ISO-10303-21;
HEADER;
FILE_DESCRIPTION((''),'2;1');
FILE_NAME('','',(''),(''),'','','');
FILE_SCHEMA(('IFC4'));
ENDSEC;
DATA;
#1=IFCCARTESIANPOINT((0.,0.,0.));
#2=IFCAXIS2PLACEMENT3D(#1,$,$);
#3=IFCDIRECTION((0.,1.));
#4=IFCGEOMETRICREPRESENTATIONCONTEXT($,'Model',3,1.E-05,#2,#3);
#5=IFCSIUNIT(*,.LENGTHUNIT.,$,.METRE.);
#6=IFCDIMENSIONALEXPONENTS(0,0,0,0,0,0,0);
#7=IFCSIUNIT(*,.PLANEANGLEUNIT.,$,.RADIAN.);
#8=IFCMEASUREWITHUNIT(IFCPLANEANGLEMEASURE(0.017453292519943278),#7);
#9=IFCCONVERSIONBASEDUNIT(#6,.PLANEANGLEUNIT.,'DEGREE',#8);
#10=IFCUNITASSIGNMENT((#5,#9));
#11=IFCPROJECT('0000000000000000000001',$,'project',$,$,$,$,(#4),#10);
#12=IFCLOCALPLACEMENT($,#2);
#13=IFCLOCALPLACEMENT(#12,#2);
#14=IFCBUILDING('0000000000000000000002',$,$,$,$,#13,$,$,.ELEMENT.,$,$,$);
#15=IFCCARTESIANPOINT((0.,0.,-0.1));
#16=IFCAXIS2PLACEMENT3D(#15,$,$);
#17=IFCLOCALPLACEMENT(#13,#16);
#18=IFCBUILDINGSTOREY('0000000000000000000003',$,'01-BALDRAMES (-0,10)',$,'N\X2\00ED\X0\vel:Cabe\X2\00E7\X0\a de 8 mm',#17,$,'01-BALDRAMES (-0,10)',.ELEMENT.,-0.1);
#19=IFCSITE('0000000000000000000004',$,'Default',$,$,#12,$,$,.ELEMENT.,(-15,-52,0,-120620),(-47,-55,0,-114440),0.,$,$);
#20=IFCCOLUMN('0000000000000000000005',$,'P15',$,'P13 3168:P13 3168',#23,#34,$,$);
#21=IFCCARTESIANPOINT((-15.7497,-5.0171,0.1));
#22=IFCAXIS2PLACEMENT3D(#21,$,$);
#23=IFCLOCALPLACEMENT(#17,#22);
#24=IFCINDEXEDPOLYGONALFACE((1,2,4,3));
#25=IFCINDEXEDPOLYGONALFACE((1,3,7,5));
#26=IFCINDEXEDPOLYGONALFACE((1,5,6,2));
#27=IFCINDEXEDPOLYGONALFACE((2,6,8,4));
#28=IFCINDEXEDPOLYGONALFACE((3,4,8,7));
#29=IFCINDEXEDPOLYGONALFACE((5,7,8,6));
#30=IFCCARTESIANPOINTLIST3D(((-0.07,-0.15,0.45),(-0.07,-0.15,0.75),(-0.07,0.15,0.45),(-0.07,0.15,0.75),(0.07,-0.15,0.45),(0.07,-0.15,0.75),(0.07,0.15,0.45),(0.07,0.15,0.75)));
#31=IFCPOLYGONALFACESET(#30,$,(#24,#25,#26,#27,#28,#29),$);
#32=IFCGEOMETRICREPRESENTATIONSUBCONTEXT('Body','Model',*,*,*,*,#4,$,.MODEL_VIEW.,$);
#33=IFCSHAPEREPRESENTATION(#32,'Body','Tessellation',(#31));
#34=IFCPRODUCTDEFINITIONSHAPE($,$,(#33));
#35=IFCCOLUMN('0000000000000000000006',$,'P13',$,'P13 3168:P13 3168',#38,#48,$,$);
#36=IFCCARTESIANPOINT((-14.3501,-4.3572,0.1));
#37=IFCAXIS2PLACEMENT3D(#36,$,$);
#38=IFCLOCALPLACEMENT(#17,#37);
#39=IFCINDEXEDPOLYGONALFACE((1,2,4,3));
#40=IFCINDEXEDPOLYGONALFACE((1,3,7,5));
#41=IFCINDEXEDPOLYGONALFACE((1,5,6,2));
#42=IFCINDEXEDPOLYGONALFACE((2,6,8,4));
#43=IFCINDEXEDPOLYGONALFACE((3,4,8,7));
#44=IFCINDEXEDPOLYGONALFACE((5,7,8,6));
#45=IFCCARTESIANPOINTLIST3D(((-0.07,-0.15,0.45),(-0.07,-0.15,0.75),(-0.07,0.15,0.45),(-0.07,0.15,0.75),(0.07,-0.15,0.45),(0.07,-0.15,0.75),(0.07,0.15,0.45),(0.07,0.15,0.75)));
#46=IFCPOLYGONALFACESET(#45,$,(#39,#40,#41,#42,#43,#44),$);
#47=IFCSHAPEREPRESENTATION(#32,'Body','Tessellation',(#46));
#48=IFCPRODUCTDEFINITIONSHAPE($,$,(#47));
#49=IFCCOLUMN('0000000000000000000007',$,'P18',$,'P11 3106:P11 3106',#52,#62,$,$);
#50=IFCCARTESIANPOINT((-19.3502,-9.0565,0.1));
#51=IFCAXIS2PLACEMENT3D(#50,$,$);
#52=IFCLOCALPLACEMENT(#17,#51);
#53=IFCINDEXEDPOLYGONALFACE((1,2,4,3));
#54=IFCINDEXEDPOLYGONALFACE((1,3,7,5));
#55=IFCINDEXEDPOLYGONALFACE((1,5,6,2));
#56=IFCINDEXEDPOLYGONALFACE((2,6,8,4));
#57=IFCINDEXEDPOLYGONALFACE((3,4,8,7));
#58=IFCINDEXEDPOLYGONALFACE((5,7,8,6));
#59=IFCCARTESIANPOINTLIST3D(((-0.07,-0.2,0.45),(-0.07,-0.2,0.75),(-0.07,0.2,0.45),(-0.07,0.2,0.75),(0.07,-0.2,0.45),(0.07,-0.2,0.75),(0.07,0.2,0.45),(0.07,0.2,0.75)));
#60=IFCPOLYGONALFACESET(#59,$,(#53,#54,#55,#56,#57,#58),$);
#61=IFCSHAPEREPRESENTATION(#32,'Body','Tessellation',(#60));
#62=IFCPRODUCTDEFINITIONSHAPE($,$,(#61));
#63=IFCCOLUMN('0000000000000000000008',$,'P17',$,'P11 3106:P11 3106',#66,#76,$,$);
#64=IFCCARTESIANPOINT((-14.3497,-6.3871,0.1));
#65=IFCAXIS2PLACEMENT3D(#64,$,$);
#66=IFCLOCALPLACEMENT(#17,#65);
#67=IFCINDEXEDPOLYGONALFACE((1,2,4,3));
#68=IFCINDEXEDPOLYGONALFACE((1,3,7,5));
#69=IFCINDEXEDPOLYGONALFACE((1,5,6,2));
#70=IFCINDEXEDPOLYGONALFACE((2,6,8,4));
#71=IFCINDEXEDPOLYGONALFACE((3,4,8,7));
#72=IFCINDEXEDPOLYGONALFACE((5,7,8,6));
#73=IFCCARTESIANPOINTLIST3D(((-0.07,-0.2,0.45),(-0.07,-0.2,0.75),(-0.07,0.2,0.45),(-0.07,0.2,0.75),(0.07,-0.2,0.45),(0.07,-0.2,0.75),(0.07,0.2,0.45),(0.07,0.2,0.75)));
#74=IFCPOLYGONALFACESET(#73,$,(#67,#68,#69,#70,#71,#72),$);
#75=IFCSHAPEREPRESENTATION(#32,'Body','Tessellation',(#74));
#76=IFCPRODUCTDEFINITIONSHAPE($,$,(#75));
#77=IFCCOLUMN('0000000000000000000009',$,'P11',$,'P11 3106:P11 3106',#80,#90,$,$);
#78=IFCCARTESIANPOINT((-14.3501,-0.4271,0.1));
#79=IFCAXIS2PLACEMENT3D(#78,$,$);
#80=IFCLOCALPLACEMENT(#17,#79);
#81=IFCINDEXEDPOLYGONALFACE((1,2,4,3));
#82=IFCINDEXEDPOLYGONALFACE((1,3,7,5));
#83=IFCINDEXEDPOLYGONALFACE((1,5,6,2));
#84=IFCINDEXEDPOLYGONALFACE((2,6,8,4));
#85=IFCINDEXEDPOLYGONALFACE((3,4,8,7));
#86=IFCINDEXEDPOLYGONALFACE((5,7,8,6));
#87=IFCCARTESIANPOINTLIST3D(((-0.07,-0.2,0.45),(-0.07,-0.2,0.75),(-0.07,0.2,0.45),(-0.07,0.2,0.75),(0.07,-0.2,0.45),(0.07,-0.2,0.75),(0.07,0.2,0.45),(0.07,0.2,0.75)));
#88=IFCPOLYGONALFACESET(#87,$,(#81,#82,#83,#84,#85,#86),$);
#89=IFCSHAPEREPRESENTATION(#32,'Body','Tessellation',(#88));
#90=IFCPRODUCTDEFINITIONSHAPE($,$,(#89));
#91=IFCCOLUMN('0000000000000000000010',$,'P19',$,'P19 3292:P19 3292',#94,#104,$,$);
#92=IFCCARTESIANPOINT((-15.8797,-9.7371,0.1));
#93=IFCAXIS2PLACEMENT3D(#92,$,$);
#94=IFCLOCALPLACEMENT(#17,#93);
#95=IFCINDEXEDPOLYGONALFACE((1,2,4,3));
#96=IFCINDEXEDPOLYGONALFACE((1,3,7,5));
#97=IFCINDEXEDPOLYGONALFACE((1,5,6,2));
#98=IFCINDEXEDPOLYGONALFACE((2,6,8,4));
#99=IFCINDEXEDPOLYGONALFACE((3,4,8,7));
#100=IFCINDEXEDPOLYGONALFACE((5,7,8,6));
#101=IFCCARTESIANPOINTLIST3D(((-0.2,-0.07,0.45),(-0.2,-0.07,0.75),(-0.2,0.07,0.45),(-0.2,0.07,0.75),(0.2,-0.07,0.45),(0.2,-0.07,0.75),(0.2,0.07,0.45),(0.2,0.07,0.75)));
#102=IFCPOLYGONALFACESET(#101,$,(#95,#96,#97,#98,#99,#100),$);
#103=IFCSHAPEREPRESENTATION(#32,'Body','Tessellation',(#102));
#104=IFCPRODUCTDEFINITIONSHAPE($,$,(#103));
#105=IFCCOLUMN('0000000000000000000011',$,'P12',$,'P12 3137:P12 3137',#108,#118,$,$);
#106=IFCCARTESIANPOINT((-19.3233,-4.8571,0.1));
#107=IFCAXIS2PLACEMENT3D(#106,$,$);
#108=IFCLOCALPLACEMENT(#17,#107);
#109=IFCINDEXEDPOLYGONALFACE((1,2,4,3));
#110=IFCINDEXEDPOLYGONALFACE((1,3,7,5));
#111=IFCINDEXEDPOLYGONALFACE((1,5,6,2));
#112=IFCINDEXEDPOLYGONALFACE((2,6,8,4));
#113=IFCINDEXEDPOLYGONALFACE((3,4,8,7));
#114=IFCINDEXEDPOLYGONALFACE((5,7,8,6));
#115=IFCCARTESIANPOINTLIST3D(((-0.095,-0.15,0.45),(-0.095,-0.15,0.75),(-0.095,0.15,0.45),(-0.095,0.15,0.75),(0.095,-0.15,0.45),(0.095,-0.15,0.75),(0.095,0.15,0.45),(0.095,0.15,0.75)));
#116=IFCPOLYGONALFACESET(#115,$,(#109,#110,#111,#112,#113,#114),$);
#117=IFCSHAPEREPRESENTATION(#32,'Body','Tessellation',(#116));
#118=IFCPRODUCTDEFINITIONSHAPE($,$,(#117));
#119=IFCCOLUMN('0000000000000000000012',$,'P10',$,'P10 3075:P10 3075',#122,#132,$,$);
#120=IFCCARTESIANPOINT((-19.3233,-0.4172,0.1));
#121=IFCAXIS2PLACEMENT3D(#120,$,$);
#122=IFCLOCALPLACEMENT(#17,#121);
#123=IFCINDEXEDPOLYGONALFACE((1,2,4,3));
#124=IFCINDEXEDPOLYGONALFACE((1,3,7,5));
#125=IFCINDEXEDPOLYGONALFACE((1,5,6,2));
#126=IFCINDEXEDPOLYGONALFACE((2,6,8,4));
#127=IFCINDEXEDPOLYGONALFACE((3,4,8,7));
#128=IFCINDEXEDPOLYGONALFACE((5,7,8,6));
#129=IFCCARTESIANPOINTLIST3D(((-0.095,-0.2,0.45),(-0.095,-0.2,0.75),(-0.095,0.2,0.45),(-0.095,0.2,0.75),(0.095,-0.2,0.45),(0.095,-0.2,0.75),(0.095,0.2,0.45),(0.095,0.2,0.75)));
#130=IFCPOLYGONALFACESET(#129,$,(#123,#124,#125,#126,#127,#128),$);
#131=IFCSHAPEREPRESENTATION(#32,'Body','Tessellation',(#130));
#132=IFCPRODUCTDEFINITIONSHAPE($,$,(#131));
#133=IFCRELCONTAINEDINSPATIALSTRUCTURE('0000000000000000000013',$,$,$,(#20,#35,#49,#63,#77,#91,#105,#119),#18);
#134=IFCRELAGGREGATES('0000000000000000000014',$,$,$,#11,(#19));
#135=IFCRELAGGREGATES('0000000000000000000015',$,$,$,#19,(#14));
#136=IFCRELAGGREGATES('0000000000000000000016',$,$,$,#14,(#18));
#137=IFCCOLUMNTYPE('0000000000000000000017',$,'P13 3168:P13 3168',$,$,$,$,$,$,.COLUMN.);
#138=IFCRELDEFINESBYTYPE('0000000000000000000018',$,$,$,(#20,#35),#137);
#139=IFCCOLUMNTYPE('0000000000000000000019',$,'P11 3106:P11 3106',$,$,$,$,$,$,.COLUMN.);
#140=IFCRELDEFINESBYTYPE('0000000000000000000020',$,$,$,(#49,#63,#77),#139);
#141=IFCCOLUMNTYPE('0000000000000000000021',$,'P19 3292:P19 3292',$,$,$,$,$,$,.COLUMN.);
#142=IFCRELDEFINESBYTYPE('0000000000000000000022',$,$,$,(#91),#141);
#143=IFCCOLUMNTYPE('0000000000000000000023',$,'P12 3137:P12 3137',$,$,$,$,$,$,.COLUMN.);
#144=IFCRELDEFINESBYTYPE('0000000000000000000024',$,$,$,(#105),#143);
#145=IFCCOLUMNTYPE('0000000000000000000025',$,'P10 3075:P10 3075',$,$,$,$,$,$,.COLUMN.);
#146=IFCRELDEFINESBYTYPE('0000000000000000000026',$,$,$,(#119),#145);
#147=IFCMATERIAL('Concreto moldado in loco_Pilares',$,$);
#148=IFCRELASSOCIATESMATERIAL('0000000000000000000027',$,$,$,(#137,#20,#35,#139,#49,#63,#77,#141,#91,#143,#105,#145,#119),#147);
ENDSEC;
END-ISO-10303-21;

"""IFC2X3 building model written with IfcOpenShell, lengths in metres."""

from ifc_helpers import new_model, entity, si_unit, converted_unit, direction, frame, origin, origin_2d_with_axis, place, context, subcontext, project, spatial, rectangle, extrude, source, transform, mapped, material, type_object, type_shapes, element, save


model = new_model("IFC2X3")

# Units and contexts
model_context = context("Model", 3, precision=1e-05, world=origin(), true_north=direction((0.0, 1.0)))
body_context = subcontext(model_context, "Body", "Model", "MODEL_VIEW")
ifc_project = project(units=[si_unit("LENGTHUNIT", "METRE"), converted_unit("PLANEANGLEUNIT", "DEGREE", entity("IfcPlaneAngleMeasure", 0.017453292519943278), si_unit("PLANEANGLEUNIT", "RADIAN"), dimensions=[0, 0, 0, 0, 0, 0, 0])], contexts=[model_context])

# Site, building, storey
site_placement = place(None, origin())
site = spatial("IfcSite", under=ifc_project, at=site_placement, Name="Default", CompositionType="ELEMENT", RefLatitude=(-15, -52, 0, -120620), RefLongitude=(-47, -55, 0, -114440), RefElevation=0.0)
building_placement = place(site_placement, origin())
building = spatial("IfcBuilding", under=site, at=building_placement, CompositionType="ELEMENT")
storey_placement = place(building_placement, frame((0.0, 0.0, -0.1)))
storey = spatial("IfcBuildingStorey", under=building, at=storey_placement, Name="01-BALDRAMES (-0,10)", ObjectType="Nível:Cabeça de 8 mm", LongName="01-BALDRAMES (-0,10)", CompositionType="ELEMENT", Elevation=-0.1)

# Columns
ifc_material_1 = material(Name="Concreto moldado in loco_Pilares")
column_type_1 = type_object("IfcColumnType", Name="P13 3168:P13 3168", PredefinedType="COLUMN", material=ifc_material_1)
shared_shape_1 = source(origin(), body_context, "Body", "SweptSolid", [
    extrude(rectangle(XDim=0.3, YDim=0.14, at=origin_2d_with_axis()), frame((0.0, 0.0, 0.45), z_axis=(0.0, 0.0, 1.0), x_axis=(0.0, -1.0, 0.0)), (0.0, 0.0, 1.0), 0.3),
])
type_shapes(column_type_1, [shared_shape_1])
for number, where, name in (
    (1, (-15.7497, -5.0171, 0.1), "P15"),
    (2, (-14.3501, -4.3572, 0.1), "P13"),
):
    element("IfcColumn", number, at=place(storey_placement, frame(where)), inside=storey, type_object=column_type_1, material=ifc_material_1, Name=name, ObjectType="P13 3168:P13 3168", context=body_context, shape_type="MappedRepresentation", body=[
        mapped(shared_shape_1, transform((0.0, 0.0, 0.0), scale=1.0)),
    ])
column_type_2 = type_object("IfcColumnType", Name="P11 3106:P11 3106", PredefinedType="COLUMN", material=ifc_material_1)
shared_shape_2 = source(origin(), body_context, "Body", "SweptSolid", [
    extrude(rectangle(XDim=0.4, YDim=0.14, at=origin_2d_with_axis()), frame((0.0, 0.0, 0.45), z_axis=(0.0, 0.0, 1.0), x_axis=(0.0, -1.0, 0.0)), (0.0, 0.0, 1.0), 0.3),
])
type_shapes(column_type_2, [shared_shape_2])
for number, where, name in (
    (3, (-19.3502, -9.0565, 0.1), "P18"),
    (4, (-14.3497, -6.3871, 0.1), "P17"),
    (5, (-14.3501, -0.4271, 0.1), "P11"),
):
    element("IfcColumn", number, at=place(storey_placement, frame(where)), inside=storey, type_object=column_type_2, material=ifc_material_1, Name=name, ObjectType="P11 3106:P11 3106", context=body_context, shape_type="MappedRepresentation", body=[
        mapped(shared_shape_2, transform((0.0, 0.0, 0.0), scale=1.0)),
    ])
column_type_3 = type_object("IfcColumnType", Name="P19 3292:P19 3292", PredefinedType="COLUMN", material=ifc_material_1)
shared_shape_3 = source(origin(), body_context, "Body", "SweptSolid", [
    extrude(rectangle(XDim=0.4, YDim=0.14, at=origin_2d_with_axis()), frame((0.0, 0.0, 0.45)), (0.0, 0.0, 1.0), 0.3),
])
type_shapes(column_type_3, [shared_shape_3])
column_1_placement = place(storey_placement, frame((-15.8797, -9.7371, 0.1)))
element("IfcColumn", 6, at=column_1_placement, inside=storey, type_object=column_type_3, material=ifc_material_1, Name="P19", ObjectType="P19 3292:P19 3292", context=body_context, shape_type="MappedRepresentation", body=[
    mapped(shared_shape_3, transform((0.0, 0.0, 0.0), scale=1.0)),
])
column_type_4 = type_object("IfcColumnType", Name="P12 3137:P12 3137", PredefinedType="COLUMN", material=ifc_material_1)
shared_shape_4 = source(origin(), body_context, "Body", "SweptSolid", [
    extrude(rectangle(XDim=0.3, YDim=0.19, at=origin_2d_with_axis()), frame((0.0, 0.0, 0.45), z_axis=(0.0, 0.0, 1.0), x_axis=(0.0, -1.0, 0.0)), (0.0, 0.0, 1.0), 0.3),
])
type_shapes(column_type_4, [shared_shape_4])
column_2_placement = place(storey_placement, frame((-19.3233, -4.8571, 0.1)))
element("IfcColumn", 7, at=column_2_placement, inside=storey, type_object=column_type_4, material=ifc_material_1, Name="P12", ObjectType="P12 3137:P12 3137", context=body_context, shape_type="MappedRepresentation", body=[
    mapped(shared_shape_4, transform((0.0, 0.0, 0.0), scale=1.0)),
])
column_type_5 = type_object("IfcColumnType", Name="P10 3075:P10 3075", PredefinedType="COLUMN", material=ifc_material_1)
shared_shape_5 = source(origin(), body_context, "Body", "SweptSolid", [
    extrude(rectangle(XDim=0.4, YDim=0.19, at=origin_2d_with_axis()), frame((0.0, 0.0, 0.45), z_axis=(0.0, 0.0, 1.0), x_axis=(0.0, -1.0, 0.0)), (0.0, 0.0, 1.0), 0.3),
])
type_shapes(column_type_5, [shared_shape_5])
column_3_placement = place(storey_placement, frame((-19.3233, -0.4172, 0.1)))
element("IfcColumn", 8, at=column_3_placement, inside=storey, type_object=column_type_5, material=ifc_material_1, Name="P10", ObjectType="P10 3075:P10 3075", context=body_context, shape_type="MappedRepresentation", body=[
    mapped(shared_shape_5, transform((0.0, 0.0, 0.0), scale=1.0)),
])

save(model, "model.ifc")
